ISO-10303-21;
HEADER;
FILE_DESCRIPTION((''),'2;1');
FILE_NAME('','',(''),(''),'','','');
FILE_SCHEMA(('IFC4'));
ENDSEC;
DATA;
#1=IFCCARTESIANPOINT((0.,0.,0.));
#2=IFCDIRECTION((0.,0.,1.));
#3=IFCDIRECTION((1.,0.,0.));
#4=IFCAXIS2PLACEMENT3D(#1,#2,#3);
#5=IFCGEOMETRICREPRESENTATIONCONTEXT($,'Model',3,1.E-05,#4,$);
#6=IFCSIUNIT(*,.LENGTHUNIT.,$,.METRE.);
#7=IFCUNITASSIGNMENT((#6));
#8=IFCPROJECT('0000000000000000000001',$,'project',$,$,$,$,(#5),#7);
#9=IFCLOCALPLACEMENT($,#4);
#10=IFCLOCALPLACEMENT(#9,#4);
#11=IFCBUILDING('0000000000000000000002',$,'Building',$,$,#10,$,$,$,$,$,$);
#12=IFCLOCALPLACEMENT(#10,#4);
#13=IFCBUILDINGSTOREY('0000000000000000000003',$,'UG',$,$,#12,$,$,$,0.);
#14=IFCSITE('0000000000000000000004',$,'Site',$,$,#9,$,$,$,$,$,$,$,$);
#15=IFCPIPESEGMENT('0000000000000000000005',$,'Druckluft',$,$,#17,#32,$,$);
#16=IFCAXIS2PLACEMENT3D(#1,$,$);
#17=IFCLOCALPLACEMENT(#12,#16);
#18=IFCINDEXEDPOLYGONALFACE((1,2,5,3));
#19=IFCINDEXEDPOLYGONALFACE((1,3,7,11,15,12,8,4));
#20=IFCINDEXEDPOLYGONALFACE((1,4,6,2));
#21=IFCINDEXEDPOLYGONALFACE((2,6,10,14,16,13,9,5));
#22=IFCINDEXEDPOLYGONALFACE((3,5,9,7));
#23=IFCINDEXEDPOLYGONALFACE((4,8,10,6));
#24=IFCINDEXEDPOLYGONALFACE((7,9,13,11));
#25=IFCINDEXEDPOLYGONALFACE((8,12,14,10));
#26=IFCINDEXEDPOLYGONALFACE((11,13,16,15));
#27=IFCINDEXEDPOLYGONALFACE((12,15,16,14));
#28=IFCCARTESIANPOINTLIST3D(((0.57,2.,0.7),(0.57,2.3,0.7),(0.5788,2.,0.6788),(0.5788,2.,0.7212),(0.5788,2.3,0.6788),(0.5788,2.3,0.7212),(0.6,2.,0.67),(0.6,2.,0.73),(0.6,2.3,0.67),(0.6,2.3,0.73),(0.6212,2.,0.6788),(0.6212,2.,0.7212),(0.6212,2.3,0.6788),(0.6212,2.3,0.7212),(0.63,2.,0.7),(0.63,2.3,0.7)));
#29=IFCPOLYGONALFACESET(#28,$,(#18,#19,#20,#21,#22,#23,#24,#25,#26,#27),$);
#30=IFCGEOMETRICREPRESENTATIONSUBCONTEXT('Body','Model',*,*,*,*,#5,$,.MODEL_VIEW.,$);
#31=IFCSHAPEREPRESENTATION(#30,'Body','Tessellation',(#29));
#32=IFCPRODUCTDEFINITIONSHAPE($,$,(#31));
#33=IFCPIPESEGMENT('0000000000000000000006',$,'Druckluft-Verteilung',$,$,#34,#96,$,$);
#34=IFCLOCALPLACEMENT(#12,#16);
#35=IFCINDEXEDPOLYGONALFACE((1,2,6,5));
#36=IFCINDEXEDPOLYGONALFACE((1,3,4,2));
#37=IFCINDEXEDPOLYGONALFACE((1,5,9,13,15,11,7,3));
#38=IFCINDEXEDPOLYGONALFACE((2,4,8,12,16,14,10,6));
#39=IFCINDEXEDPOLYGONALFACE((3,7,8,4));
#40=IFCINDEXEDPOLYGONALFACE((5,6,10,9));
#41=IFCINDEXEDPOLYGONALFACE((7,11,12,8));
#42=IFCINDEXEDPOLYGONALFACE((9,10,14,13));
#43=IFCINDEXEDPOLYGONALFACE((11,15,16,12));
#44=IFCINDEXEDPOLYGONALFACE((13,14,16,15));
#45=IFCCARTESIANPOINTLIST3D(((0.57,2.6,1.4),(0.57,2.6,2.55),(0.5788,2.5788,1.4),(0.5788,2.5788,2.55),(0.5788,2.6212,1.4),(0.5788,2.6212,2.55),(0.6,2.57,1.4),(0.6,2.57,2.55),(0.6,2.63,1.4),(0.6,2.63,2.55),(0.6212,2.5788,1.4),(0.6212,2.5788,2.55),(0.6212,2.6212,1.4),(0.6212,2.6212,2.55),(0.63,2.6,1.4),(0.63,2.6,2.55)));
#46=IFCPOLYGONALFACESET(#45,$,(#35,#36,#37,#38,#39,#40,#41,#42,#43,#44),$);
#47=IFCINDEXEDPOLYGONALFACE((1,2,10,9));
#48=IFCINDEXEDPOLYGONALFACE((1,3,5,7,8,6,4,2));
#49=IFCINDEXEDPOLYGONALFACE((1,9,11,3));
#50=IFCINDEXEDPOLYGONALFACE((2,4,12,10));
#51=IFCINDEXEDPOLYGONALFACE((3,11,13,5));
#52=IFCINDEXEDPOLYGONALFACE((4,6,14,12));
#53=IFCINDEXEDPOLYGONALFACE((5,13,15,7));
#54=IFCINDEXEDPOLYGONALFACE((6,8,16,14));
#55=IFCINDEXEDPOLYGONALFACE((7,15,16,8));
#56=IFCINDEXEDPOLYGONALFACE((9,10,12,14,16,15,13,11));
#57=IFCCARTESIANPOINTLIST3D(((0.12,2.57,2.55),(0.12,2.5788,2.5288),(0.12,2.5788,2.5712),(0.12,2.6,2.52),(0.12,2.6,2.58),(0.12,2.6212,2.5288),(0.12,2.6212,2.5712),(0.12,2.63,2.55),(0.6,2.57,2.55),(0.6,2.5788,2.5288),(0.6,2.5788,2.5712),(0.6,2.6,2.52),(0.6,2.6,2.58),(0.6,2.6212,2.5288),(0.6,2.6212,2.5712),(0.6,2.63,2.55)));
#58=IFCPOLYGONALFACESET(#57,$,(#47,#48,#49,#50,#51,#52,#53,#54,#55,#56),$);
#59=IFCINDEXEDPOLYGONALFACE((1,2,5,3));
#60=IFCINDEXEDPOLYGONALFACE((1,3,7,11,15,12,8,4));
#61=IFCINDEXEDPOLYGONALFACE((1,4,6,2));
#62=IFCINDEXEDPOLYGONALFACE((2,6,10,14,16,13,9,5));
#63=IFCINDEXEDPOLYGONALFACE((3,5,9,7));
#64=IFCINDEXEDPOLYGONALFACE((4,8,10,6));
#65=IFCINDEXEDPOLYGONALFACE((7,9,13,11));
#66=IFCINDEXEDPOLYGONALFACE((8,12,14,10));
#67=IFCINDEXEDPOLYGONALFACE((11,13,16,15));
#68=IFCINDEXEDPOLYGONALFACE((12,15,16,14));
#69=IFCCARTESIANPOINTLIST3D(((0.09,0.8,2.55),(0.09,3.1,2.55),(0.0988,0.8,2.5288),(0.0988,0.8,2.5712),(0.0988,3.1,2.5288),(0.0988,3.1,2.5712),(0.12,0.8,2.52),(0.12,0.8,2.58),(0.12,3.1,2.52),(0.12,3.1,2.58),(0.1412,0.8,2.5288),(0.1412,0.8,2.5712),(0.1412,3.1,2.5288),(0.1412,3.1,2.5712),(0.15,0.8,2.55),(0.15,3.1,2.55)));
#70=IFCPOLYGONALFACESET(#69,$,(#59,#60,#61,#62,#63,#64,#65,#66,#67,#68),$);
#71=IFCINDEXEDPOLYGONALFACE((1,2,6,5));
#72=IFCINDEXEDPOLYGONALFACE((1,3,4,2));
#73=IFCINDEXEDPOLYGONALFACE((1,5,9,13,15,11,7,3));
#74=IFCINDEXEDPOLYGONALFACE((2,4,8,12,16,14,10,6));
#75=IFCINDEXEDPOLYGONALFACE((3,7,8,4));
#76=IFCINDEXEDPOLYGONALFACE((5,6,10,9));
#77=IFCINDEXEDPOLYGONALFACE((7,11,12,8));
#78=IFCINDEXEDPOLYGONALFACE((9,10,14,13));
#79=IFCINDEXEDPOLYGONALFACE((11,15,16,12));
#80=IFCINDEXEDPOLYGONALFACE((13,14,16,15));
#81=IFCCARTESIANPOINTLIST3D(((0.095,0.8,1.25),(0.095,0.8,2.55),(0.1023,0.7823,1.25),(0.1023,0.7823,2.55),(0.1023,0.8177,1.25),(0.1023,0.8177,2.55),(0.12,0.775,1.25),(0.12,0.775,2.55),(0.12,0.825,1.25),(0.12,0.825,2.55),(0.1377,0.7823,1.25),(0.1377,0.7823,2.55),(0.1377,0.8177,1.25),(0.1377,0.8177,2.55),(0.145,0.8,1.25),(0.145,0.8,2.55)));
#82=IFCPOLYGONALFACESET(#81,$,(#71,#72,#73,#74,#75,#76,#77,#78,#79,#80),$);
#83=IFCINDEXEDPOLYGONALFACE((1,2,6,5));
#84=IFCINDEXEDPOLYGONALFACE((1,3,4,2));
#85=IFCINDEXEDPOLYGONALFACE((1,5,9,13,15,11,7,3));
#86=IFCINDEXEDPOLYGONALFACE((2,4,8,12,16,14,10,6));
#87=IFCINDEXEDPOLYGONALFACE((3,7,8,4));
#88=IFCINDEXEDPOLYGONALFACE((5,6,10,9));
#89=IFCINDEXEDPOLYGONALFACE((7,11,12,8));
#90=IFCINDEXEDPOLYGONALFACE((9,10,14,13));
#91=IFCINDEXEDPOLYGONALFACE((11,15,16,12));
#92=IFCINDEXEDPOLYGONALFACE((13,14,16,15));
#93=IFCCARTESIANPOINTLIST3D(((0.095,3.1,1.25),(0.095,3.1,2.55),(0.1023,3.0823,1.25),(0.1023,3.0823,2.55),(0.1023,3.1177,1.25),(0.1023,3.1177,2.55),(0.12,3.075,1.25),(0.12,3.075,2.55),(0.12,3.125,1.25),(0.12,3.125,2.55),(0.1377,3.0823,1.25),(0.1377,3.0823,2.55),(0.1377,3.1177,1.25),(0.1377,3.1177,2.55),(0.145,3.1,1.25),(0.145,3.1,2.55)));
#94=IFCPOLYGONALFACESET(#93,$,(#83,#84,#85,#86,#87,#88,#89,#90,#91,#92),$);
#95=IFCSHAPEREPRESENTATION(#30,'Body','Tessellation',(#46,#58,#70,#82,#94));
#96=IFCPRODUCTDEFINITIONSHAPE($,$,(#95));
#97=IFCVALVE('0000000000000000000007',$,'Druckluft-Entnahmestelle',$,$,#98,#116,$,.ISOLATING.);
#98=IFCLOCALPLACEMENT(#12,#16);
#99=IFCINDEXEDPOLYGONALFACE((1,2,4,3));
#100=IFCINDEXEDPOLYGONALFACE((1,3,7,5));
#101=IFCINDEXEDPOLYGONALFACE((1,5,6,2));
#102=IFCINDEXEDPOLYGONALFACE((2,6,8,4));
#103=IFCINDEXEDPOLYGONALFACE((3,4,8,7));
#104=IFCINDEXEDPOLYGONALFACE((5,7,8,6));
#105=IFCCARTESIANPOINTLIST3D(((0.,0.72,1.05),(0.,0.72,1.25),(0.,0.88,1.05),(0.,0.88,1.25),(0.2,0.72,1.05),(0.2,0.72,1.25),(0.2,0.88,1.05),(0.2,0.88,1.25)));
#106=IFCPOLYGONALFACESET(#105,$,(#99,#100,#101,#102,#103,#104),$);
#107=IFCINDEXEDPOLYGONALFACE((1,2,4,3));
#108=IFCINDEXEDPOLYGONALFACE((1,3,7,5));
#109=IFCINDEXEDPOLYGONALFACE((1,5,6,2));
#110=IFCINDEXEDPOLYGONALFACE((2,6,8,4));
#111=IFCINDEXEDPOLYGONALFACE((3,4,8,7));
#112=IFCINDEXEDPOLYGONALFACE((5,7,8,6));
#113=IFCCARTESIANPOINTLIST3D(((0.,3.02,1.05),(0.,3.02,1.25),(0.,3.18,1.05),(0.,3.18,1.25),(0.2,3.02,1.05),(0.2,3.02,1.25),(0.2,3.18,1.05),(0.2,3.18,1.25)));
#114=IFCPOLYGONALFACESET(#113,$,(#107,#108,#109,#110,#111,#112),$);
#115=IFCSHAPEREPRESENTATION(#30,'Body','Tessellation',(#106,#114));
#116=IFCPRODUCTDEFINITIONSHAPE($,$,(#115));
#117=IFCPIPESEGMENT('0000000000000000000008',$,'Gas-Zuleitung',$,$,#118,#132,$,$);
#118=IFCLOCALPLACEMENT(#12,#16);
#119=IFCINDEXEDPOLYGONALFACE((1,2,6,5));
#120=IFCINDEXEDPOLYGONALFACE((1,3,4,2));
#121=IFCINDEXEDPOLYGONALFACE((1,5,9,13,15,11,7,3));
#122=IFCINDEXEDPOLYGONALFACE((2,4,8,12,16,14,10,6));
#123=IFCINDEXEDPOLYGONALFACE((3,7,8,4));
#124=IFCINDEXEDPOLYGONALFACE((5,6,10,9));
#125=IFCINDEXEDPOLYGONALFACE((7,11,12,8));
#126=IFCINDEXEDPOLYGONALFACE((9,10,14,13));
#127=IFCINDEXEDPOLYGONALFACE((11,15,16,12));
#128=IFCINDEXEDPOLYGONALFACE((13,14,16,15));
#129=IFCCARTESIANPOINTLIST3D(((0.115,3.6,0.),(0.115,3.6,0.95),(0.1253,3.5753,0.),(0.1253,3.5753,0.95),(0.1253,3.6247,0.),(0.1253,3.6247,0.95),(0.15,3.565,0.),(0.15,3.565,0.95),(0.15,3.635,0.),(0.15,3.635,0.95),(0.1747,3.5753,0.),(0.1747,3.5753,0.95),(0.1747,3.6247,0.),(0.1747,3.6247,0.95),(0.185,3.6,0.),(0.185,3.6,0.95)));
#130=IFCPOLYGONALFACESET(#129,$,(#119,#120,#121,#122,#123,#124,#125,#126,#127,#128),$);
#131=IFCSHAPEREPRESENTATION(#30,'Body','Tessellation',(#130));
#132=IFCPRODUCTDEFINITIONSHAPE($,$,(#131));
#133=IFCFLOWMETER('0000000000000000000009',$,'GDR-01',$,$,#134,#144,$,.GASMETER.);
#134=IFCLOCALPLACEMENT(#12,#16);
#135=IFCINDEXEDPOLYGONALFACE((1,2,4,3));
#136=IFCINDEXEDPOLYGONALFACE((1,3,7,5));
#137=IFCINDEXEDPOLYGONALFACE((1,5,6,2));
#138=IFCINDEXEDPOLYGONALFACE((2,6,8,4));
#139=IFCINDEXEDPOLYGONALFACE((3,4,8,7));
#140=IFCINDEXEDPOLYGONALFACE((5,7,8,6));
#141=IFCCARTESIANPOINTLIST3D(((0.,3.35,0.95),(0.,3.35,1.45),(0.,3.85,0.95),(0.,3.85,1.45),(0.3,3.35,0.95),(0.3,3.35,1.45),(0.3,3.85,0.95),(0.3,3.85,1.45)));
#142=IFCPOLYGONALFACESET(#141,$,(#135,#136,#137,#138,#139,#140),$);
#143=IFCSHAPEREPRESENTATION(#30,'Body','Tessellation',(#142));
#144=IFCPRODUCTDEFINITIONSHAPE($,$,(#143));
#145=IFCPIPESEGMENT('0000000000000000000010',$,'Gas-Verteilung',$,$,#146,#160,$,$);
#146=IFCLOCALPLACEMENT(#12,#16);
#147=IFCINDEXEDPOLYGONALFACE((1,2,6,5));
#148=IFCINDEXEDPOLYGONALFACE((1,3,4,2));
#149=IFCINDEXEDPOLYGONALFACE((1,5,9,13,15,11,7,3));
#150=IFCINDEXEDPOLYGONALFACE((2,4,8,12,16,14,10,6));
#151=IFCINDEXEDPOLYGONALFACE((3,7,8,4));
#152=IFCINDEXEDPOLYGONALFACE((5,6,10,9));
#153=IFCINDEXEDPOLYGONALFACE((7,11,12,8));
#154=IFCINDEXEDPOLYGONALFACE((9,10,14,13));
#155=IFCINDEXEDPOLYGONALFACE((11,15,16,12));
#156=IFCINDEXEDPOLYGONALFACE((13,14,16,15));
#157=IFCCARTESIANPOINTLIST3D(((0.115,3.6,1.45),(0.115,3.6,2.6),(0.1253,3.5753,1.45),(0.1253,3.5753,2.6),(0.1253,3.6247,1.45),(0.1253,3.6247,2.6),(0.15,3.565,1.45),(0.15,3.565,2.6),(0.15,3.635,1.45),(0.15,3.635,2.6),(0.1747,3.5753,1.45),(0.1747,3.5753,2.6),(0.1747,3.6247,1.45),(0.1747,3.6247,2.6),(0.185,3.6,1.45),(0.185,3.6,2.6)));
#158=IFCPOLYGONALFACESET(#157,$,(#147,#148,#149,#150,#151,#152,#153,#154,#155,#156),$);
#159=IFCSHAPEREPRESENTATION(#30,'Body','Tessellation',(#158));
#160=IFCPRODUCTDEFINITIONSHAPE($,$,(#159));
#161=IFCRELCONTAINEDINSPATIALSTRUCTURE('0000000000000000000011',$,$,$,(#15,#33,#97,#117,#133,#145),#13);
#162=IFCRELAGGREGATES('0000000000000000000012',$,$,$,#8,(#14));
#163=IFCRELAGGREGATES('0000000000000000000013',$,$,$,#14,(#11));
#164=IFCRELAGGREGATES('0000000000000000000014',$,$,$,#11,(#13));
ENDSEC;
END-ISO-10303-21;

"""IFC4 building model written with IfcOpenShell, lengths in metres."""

from ifc_helpers import new_model, si_unit, frame, origin_with_axes, place, context, subcontext, project, spatial, polyline, outline, extrude, element, save


model = new_model("IFC4")

# Units and contexts
model_context = context("Model", 3, precision=1e-05, world=origin_with_axes())
body_context = subcontext(model_context, "Body", "Model", "MODEL_VIEW")
ifc_project = project(units=[si_unit("LENGTHUNIT", "METRE")], contexts=[model_context])

# Site, building, storey
site_placement = place(None, origin_with_axes())
site = spatial("IfcSite", under=ifc_project, at=site_placement, Name="Site")
building_placement = place(site_placement, origin_with_axes())
building = spatial("IfcBuilding", under=site, at=building_placement, Name="Building")
storey_placement = place(building_placement, origin_with_axes())
storey = spatial("IfcBuildingStorey", under=building, at=storey_placement, Name="UG", Elevation=0.0)

# Pipe segments
pipe_segment_1_placement = place(storey_placement, origin_with_axes())
element("IfcPipeSegment", 1, at=pipe_segment_1_placement, inside=storey, Name="Druckluft", context=body_context, shape_type="SweptSolid", body=[
    extrude(outline(polyline([(0.03, 0.0, 0.0), (0.0212, 0.0212, 0.0), (0.0, 0.03, 0.0), (-0.0212, 0.0212, 0.0), (-0.03, 0.0, 0.0), (-0.0212, -0.0212, 0.0), (0.0, -0.03, 0.0), (0.0212, -0.0212, 0.0), (0.03, 0.0, 0.0)])), frame((0.6, 2.0, 0.7), z_axis=(0.0, 1.0, 0.0), x_axis=(-1.0, 0.0, 0.0)), (0.0, 0.0, 1.0), 0.3),
])
pipe_segment_2_placement = place(storey_placement, origin_with_axes())
element("IfcPipeSegment", 2, at=pipe_segment_2_placement, inside=storey, Name="Druckluft-Verteilung", context=body_context, shape_type="SweptSolid", body=[
    extrude(outline(polyline([(0.03, 0.0, 0.0), (0.0212, 0.0212, 0.0), (0.0, 0.03, 0.0), (-0.0212, 0.0212, 0.0), (-0.03, 0.0, 0.0), (-0.0212, -0.0212, 0.0), (0.0, -0.03, 0.0), (0.0212, -0.0212, 0.0), (0.03, 0.0, 0.0)])), frame((0.6, 2.6, 1.4), z_axis=(0.0, 0.0, 1.0), x_axis=(1.0, 0.0, 0.0)), (0.0, 0.0, 1.0), 1.15),
    extrude(outline(polyline([(0.03, 0.0, 0.0), (0.0212, 0.0212, 0.0), (0.0, 0.03, 0.0), (-0.0212, 0.0212, 0.0), (-0.03, 0.0, 0.0), (-0.0212, -0.0212, 0.0), (0.0, -0.03, 0.0), (0.0212, -0.0212, 0.0), (0.03, 0.0, 0.0)])), frame((0.6, 2.6, 2.55), z_axis=(-1.0, 0.0, 0.0), x_axis=(0.0, -1.0, 0.0)), (0.0, 0.0, 1.0), 0.48),
    extrude(outline(polyline([(0.03, 0.0, 0.0), (0.0212, 0.0212, 0.0), (0.0, 0.03, 0.0), (-0.0212, 0.0212, 0.0), (-0.03, 0.0, 0.0), (-0.0212, -0.0212, 0.0), (0.0, -0.03, 0.0), (0.0212, -0.0212, 0.0), (0.03, 0.0, 0.0)])), frame((0.12, 0.8, 2.55), z_axis=(0.0, 1.0, 0.0), x_axis=(-1.0, 0.0, 0.0)), (0.0, 0.0, 1.0), 2.3),
    extrude(outline(polyline([(0.025, 0.0, 0.0), (0.0177, 0.0177, 0.0), (0.0, 0.025, 0.0), (-0.0177, 0.0177, 0.0), (-0.025, 0.0, 0.0), (-0.0177, -0.0177, 0.0), (0.0, -0.025, 0.0), (0.0177, -0.0177, 0.0), (0.025, 0.0, 0.0)])), frame((0.12, 0.8, 2.55), z_axis=(0.0, 0.0, -1.0), x_axis=(1.0, 0.0, 0.0)), (0.0, 0.0, 1.0), 1.3),
    extrude(outline(polyline([(0.025, 0.0, 0.0), (0.0177, 0.0177, 0.0), (0.0, 0.025, 0.0), (-0.0177, 0.0177, 0.0), (-0.025, 0.0, 0.0), (-0.0177, -0.0177, 0.0), (0.0, -0.025, 0.0), (0.0177, -0.0177, 0.0), (0.025, 0.0, 0.0)])), frame((0.12, 3.1, 2.55), z_axis=(0.0, 0.0, -1.0), x_axis=(1.0, 0.0, 0.0)), (0.0, 0.0, 1.0), 1.3),
])

# Valve
valve_placement = place(storey_placement, origin_with_axes())
element("IfcValve", 3, at=valve_placement, inside=storey, Name="Druckluft-Entnahmestelle", PredefinedType="ISOLATING", context=body_context, shape_type="SweptSolid", body=[
    extrude(outline(polyline([(0.0, 0.72, 0.0), (0.2, 0.72, 0.0), (0.2, 0.88, 0.0), (0.0, 0.88, 0.0), (0.0, 0.72, 0.0)])), frame((0.0, 0.0, 1.05), z_axis=(0.0, 0.0, 1.0), x_axis=(1.0, 0.0, 0.0)), (0.0, 0.0, 1.0), 0.2),
    extrude(outline(polyline([(0.0, 3.02, 0.0), (0.2, 3.02, 0.0), (0.2, 3.18, 0.0), (0.0, 3.18, 0.0), (0.0, 3.02, 0.0)])), frame((0.0, 0.0, 1.05), z_axis=(0.0, 0.0, 1.0), x_axis=(1.0, 0.0, 0.0)), (0.0, 0.0, 1.0), 0.2),
])

# Pipe segment
pipe_segment_3_placement = place(storey_placement, origin_with_axes())
element("IfcPipeSegment", 4, at=pipe_segment_3_placement, inside=storey, Name="Gas-Zuleitung", context=body_context, shape_type="SweptSolid", body=[
    extrude(outline(polyline([(0.035, 0.0, 0.0), (0.0247, 0.0247, 0.0), (0.0, 0.035, 0.0), (-0.0247, 0.0247, 0.0), (-0.035, 0.0, 0.0), (-0.0247, -0.0247, 0.0), (0.0, -0.035, 0.0), (0.0247, -0.0247, 0.0), (0.035, 0.0, 0.0)])), frame((0.15, 3.6, 0.0), z_axis=(0.0, 0.0, 1.0), x_axis=(1.0, 0.0, 0.0)), (0.0, 0.0, 1.0), 0.95),
])

# Flow meter
flow_meter_placement = place(storey_placement, origin_with_axes())
element("IfcFlowMeter", 5, at=flow_meter_placement, inside=storey, Name="GDR-01", PredefinedType="GASMETER", context=body_context, shape_type="SweptSolid", body=[
    extrude(outline(polyline([(0.0, 3.35, 0.0), (0.3, 3.35, 0.0), (0.3, 3.85, 0.0), (0.0, 3.85, 0.0), (0.0, 3.35, 0.0)])), frame((0.0, 0.0, 0.95), z_axis=(0.0, 0.0, 1.0), x_axis=(1.0, 0.0, 0.0)), (0.0, 0.0, 1.0), 0.5),
])

# Pipe segment
pipe_segment_4_placement = place(storey_placement, origin_with_axes())
element("IfcPipeSegment", 6, at=pipe_segment_4_placement, inside=storey, Name="Gas-Verteilung", context=body_context, shape_type="SweptSolid", body=[
    extrude(outline(polyline([(0.035, 0.0, 0.0), (0.0247, 0.0247, 0.0), (0.0, 0.035, 0.0), (-0.0247, 0.0247, 0.0), (-0.035, 0.0, 0.0), (-0.0247, -0.0247, 0.0), (0.0, -0.035, 0.0), (0.0247, -0.0247, 0.0), (0.035, 0.0, 0.0)])), frame((0.15, 3.6, 1.45), z_axis=(0.0, 0.0, 1.0), x_axis=(1.0, 0.0, 0.0)), (0.0, 0.0, 1.0), 1.15),
])

save(model, "model.ifc")
